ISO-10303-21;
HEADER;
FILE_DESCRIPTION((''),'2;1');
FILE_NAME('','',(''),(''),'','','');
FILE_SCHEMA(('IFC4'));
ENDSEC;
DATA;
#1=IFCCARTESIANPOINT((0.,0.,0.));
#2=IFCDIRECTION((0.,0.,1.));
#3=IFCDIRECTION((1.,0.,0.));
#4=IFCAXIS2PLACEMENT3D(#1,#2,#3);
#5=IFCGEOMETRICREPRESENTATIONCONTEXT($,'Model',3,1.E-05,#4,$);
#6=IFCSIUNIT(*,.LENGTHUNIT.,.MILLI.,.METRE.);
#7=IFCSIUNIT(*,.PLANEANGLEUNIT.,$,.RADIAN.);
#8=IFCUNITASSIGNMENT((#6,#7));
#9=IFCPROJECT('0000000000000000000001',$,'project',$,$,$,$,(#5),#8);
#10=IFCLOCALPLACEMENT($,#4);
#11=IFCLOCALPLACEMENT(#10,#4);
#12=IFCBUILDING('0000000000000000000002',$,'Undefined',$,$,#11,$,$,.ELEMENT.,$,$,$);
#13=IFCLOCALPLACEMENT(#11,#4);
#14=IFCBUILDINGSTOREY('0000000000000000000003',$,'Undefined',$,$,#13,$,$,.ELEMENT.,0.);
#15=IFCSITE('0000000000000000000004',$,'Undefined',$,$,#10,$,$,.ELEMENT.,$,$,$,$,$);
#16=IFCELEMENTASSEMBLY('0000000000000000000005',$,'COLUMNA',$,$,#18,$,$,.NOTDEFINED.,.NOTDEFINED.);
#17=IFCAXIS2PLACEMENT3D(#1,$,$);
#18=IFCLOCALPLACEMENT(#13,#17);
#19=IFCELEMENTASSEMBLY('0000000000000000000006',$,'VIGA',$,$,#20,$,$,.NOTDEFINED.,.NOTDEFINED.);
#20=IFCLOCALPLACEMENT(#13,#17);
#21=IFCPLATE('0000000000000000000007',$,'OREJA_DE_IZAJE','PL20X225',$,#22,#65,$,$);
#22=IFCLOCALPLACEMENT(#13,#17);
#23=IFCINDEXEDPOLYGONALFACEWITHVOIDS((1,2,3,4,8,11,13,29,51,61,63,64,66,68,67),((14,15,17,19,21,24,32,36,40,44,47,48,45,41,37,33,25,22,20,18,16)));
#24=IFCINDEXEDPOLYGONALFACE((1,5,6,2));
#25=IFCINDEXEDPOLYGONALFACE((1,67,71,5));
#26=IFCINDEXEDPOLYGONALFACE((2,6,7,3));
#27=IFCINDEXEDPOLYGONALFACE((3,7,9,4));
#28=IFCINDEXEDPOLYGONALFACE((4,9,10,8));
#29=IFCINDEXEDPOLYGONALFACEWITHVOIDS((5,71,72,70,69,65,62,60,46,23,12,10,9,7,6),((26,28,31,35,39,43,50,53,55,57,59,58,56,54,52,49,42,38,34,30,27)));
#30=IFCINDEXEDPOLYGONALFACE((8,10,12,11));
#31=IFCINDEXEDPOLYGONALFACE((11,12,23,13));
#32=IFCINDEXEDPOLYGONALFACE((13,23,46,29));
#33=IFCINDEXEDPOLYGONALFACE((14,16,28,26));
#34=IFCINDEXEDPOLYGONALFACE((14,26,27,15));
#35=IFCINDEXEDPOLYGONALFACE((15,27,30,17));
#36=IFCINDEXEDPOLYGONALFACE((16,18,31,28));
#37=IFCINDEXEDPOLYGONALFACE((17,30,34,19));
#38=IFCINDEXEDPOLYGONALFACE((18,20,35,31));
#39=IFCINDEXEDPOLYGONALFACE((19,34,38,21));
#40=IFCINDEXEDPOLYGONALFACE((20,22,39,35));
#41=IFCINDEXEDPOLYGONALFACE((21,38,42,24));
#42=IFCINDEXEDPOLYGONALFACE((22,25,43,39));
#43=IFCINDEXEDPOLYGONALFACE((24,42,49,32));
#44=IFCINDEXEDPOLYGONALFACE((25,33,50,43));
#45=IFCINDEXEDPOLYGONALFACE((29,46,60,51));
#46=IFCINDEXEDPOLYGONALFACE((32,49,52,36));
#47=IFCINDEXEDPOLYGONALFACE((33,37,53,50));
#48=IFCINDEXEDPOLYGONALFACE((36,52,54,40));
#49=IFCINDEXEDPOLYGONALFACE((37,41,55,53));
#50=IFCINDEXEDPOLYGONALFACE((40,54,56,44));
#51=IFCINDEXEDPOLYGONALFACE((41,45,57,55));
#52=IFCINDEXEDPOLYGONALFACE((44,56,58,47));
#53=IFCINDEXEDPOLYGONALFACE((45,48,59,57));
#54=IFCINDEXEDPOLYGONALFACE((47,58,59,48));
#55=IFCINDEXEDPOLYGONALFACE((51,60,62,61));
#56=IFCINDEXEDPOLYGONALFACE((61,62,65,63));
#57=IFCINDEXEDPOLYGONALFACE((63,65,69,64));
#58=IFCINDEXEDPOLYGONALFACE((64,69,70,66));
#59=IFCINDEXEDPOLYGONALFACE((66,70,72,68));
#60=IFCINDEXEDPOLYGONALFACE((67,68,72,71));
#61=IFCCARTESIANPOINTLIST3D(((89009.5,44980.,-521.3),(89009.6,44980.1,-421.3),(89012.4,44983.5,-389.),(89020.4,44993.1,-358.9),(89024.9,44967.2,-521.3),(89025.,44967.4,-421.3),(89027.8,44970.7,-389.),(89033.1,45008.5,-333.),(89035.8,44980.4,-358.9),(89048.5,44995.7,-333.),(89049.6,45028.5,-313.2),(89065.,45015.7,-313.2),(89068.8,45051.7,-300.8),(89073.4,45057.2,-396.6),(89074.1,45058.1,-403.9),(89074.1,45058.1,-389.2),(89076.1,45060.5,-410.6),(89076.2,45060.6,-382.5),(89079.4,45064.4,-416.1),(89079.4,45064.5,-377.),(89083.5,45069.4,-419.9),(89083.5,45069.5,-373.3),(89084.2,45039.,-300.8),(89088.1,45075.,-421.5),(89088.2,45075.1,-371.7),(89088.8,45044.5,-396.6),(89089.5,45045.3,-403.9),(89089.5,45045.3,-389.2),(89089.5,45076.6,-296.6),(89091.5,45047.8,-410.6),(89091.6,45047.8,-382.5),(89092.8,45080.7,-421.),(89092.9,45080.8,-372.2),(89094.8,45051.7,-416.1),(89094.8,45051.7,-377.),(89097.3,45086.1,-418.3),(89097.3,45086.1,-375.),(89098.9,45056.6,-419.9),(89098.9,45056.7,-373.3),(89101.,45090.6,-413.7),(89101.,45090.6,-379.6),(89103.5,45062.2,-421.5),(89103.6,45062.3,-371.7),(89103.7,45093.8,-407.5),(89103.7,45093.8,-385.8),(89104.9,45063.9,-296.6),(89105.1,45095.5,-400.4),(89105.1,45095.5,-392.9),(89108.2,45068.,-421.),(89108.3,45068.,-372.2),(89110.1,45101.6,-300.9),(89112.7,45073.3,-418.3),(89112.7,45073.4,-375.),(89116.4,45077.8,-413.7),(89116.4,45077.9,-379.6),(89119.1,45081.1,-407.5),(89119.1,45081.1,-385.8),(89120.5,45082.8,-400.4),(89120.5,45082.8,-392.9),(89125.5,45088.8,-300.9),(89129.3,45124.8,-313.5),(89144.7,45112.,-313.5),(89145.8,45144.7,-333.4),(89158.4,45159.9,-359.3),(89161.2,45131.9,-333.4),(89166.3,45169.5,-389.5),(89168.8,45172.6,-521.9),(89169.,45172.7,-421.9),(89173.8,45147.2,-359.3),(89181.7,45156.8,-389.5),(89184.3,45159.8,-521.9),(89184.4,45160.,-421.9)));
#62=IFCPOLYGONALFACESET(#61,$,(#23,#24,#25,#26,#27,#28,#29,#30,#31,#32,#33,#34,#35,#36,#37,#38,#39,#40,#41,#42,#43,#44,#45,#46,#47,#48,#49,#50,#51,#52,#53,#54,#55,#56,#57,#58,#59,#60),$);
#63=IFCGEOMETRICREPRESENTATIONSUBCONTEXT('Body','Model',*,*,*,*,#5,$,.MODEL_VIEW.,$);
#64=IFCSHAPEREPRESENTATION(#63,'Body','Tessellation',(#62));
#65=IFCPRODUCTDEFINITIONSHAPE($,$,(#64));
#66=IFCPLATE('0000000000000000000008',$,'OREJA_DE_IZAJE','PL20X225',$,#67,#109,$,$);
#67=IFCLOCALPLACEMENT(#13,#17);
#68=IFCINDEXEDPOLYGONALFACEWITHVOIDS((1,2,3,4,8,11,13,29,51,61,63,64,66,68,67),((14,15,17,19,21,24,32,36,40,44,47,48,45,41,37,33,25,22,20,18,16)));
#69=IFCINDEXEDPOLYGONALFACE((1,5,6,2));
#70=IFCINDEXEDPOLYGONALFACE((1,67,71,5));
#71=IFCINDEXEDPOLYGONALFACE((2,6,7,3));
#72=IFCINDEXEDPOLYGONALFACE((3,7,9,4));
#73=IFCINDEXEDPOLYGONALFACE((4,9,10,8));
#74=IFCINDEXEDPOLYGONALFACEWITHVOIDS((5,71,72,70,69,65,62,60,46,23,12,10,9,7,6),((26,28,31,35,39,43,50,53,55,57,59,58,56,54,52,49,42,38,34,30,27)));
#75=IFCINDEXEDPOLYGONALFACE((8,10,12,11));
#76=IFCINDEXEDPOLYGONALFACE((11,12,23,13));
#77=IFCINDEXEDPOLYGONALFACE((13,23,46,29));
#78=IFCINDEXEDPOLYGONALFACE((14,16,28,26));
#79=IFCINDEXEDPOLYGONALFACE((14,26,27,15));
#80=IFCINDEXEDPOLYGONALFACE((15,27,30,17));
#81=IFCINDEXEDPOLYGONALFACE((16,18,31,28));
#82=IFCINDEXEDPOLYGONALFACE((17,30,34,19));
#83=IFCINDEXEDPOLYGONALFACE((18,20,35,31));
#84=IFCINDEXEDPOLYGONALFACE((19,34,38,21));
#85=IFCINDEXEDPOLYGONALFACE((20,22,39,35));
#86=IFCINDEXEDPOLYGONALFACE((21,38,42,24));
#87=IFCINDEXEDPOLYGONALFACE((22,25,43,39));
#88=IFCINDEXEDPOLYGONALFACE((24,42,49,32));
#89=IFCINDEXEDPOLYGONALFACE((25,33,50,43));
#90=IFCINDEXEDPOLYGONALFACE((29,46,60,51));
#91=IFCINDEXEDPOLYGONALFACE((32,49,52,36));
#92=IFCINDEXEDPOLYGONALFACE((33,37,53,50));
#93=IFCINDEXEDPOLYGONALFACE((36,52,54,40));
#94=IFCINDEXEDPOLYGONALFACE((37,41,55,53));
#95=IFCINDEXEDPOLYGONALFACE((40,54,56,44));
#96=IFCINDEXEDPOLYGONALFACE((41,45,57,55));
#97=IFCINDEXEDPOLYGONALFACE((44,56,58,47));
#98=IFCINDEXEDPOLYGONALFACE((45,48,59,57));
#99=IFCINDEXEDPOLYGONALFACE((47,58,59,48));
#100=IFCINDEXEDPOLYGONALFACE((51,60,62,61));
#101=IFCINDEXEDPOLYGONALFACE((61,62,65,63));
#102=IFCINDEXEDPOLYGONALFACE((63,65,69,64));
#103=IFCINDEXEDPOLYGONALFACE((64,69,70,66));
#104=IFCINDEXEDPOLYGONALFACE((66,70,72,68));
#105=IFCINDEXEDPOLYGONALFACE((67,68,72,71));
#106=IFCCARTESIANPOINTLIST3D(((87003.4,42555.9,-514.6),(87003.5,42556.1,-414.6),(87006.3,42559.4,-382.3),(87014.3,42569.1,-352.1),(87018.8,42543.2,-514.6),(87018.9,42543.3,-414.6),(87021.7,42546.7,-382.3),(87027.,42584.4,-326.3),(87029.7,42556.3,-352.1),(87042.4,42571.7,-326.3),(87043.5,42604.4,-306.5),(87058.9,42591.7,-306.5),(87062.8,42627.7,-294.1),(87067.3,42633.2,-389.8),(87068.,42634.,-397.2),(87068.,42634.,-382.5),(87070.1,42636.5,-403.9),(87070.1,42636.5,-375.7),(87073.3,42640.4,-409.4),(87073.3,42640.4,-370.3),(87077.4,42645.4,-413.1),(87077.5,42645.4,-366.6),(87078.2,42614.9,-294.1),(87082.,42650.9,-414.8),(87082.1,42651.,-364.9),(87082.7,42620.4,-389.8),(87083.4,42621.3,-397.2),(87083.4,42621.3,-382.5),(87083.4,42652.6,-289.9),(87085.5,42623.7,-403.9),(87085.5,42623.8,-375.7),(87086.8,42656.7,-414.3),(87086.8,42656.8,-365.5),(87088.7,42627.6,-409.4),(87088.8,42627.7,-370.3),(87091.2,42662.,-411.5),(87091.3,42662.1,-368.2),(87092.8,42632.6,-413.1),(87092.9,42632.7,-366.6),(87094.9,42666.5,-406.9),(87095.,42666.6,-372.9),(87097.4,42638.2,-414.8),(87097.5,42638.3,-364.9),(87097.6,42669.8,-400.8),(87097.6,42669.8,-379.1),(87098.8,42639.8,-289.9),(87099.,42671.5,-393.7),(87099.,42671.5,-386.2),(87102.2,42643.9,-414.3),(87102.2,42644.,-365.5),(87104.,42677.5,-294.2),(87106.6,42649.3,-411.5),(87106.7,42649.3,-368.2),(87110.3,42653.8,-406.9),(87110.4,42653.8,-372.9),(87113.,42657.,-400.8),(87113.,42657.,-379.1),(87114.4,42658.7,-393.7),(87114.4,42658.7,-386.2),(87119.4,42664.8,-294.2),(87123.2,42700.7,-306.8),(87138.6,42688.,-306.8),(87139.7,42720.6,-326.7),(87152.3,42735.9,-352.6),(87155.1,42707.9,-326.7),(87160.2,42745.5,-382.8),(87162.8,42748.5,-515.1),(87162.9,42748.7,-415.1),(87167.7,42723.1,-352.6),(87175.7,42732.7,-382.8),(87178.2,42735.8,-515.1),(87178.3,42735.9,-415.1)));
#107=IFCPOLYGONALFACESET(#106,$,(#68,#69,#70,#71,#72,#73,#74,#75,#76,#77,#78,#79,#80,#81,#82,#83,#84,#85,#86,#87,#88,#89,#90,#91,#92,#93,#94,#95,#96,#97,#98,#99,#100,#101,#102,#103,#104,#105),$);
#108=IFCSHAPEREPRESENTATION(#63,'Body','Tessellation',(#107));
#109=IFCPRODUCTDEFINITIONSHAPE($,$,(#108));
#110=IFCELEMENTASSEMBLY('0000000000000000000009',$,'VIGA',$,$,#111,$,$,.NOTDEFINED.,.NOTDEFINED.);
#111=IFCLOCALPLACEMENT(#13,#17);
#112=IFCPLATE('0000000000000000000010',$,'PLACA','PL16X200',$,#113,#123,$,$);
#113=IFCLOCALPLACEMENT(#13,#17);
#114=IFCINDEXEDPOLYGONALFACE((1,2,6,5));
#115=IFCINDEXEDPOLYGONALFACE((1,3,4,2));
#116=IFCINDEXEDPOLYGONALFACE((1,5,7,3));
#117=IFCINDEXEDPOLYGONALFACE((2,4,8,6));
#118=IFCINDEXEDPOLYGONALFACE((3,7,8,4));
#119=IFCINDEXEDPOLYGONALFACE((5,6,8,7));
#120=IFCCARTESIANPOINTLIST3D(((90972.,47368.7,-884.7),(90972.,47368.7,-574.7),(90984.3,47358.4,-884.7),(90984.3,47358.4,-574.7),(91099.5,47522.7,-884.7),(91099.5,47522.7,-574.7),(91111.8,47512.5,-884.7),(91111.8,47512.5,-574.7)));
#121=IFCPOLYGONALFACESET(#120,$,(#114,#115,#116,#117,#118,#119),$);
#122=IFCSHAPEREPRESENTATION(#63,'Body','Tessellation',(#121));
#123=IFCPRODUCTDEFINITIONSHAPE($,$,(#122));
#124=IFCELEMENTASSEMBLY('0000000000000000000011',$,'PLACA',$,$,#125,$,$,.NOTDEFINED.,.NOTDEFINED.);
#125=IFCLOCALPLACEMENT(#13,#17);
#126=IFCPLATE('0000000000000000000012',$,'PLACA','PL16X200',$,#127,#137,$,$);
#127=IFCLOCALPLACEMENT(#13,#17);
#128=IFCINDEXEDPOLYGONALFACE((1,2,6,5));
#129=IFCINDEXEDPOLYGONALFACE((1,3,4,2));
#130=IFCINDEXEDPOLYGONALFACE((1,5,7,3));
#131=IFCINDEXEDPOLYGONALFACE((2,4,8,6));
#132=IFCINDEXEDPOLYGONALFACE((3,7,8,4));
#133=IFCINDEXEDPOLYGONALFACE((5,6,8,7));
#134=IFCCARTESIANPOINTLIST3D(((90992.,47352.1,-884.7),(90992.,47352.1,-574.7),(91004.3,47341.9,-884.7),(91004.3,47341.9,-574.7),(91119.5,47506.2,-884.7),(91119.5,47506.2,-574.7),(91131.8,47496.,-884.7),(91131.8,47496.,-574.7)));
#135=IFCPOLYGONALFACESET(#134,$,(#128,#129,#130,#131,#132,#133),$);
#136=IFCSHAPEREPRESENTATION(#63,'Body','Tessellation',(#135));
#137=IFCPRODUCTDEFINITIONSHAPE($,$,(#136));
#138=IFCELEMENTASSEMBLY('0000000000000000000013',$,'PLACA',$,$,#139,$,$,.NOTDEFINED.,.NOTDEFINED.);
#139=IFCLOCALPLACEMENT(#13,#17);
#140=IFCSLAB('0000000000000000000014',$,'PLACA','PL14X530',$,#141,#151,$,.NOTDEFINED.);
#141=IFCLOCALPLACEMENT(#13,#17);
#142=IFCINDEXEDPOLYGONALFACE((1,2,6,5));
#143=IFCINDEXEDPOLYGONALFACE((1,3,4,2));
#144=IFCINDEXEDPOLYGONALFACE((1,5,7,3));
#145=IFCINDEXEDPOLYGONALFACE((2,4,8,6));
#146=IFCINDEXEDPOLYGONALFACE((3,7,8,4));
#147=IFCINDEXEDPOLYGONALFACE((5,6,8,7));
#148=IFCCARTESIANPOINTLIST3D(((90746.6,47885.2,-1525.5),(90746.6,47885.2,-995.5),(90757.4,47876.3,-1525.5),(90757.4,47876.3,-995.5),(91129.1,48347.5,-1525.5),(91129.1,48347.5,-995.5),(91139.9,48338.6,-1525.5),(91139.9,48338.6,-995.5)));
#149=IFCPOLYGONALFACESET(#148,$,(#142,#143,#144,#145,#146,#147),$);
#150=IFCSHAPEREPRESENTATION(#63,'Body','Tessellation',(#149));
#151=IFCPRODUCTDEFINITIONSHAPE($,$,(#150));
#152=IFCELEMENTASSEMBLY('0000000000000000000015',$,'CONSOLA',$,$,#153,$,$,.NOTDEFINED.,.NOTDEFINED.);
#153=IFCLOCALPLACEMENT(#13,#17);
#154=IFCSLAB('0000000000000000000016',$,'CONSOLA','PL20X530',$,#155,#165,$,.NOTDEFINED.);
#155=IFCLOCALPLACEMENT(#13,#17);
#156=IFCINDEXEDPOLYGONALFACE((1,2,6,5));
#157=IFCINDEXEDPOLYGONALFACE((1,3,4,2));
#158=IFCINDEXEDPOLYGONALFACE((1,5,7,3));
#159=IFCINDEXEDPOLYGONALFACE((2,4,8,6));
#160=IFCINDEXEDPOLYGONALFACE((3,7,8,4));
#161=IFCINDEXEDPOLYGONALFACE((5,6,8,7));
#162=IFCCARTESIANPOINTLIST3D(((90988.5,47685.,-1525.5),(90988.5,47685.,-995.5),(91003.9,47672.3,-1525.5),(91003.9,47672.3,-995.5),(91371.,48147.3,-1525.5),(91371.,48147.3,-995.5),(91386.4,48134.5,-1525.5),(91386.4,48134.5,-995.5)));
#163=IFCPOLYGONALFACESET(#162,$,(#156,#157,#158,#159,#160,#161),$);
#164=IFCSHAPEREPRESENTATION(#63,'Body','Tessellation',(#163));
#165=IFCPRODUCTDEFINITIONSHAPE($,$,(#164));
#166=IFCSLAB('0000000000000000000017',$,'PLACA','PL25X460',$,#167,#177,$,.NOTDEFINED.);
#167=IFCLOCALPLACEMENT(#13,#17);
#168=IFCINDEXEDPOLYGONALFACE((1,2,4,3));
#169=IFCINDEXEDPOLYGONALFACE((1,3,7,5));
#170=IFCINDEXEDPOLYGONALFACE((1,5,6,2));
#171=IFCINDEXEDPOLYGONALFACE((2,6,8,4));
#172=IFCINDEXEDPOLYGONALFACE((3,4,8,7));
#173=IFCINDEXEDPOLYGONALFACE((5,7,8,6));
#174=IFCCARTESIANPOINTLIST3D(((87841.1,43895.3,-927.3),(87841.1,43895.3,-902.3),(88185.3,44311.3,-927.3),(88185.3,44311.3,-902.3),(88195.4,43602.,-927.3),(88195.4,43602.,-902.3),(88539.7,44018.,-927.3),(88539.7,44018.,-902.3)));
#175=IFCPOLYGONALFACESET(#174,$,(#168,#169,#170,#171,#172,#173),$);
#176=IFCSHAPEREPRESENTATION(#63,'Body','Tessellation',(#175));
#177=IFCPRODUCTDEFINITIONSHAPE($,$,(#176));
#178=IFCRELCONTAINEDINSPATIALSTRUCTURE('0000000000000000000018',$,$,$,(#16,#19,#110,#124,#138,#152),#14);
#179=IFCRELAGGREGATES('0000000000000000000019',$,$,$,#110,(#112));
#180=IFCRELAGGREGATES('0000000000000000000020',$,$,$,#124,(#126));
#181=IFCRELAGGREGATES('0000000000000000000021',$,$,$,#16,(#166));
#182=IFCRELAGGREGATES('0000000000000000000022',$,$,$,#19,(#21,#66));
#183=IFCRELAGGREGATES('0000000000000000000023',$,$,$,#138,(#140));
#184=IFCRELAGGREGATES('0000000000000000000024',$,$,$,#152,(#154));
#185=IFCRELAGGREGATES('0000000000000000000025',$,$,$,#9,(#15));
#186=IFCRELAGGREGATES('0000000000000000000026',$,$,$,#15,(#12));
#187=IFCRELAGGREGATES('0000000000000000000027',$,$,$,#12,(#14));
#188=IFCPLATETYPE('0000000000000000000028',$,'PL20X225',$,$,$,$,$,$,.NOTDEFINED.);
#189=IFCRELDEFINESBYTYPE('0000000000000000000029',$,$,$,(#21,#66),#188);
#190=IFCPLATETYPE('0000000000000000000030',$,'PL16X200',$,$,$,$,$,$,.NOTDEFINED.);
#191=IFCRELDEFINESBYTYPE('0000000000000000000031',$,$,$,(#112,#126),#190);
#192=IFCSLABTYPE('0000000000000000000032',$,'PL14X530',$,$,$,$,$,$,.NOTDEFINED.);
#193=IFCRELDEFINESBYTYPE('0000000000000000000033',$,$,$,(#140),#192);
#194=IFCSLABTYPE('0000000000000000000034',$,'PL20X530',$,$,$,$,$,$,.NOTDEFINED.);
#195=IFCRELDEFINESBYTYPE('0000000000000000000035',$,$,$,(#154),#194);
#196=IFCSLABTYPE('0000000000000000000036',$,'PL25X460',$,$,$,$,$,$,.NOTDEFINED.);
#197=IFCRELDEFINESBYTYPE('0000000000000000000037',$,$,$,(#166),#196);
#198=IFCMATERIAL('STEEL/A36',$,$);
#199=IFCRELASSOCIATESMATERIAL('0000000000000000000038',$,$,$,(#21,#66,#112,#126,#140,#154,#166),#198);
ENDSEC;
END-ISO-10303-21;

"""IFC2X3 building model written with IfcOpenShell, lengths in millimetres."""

from ifc_helpers import new_model, si_unit, frame, frame_2d, origin_with_axes, place, context, subcontext, project, spatial, polyline, circle_curve, parameter, trimmed, segment, composite_curve, outline, extrude, boolean, material, type_object, element, aggregate, save


model = new_model("IFC2X3")

# Units and contexts
model_context = context("Model", 3, precision=1e-05, world=origin_with_axes())
body_context = subcontext(model_context, "Body", "Model", "MODEL_VIEW")
ifc_project = project(units=[si_unit("LENGTHUNIT", "METRE", prefix="MILLI"), si_unit("PLANEANGLEUNIT", "RADIAN")], contexts=[model_context])

# Site, building, storey
site_placement = place(None, origin_with_axes())
site = spatial("IfcSite", under=ifc_project, at=site_placement, Name="Undefined", CompositionType="ELEMENT")
building_placement = place(site_placement, origin_with_axes())
building = spatial("IfcBuilding", under=site, at=building_placement, Name="Undefined", CompositionType="ELEMENT")
storey_placement = place(building_placement, origin_with_axes())
storey = spatial("IfcBuildingStorey", under=building, at=storey_placement, Name="Undefined", CompositionType="ELEMENT", Elevation=0.0)

# Element assembly
assembly_1_placement = place(storey_placement, origin_with_axes())
assembly_1 = element("IfcElementAssembly", 1, at=assembly_1_placement, inside=storey, Name="COLUMNA", AssemblyPlace="NOTDEFINED", PredefinedType="NOTDEFINED")
ifc_material_1 = material(Name="STEEL/A36")

# Element assembly, plates
assembly_2_placement = place(storey_placement, origin_with_axes())
assembly_2 = element("IfcElementAssembly", 2, at=assembly_2_placement, inside=storey, Name="VIGA", AssemblyPlace="NOTDEFINED", PredefinedType="NOTDEFINED")
plate_type_1 = type_object("IfcPlateType", Name="PL20X225", PredefinedType="NOTDEFINED")
plate_1_placement = place(assembly_2_placement, frame((89017.2, 44973.6, -521.3), z_axis=(0.770401, -0.63756, 0.0), x_axis=(0.637558, 0.770399, -0.002141)))
plate_1 = element("IfcPlate", 3, at=plate_1_placement, type_object=plate_type_1, material=ifc_material_1, Name="OREJA_DE_IZAJE", Description="PL20X225", context=body_context, shape_type="CSG", body=[
    boolean("DIFFERENCE", extrude(outline(polyline([(0.0, 0.0), (250.0, 0.0), (250.0, 100.0), (245.7, 132.4), (233.3, 162.5), (213.4, 188.4), (187.5, 208.3), (157.4, 220.7), (125.0, 225.0), (125.0, 225.0), (92.6, 220.7), (62.5, 208.3), (36.6, 188.4), (16.7, 162.5), (4.3, 132.4), (0.0, 100.0), (0.0, 0.0)])), frame((0.0, 0.0, -10.0), z_axis=(0.0, 0.0, 1.0), x_axis=(1.0, 0.0, 0.0)), (0.0, 0.0, 1.0), 20.0), extrude(outline(composite_curve([segment(trimmed(circle_curve(frame_2d((17.7, 17.7), x_axis=(-0.707107, -0.707107)), 25.0), [parameter(0.0)], [parameter(3.141593)], True, "PARAMETER"), True, "CONTINUOUS"), segment(trimmed(circle_curve(frame_2d((17.7, 17.7), x_axis=(0.707107, 0.707107)), 25.0), [parameter(0.0)], [parameter(3.141593)], True, "PARAMETER"), True, "DISCONTINUOUS")], self_intersect=True)), frame((100.0, 125.0, 13.0), z_axis=(0.0, 0.0, -1.0), x_axis=(0.707096, 0.707117, 0.0)), (0.0, 0.0, 1.0), 26.0)),
])
plate_2_placement = place(assembly_2_placement, frame((87011.1, 42549.5, -514.6), z_axis=(0.770401, -0.63756, 0.0), x_axis=(0.637558, 0.770399, -0.002141)))
plate_2 = element("IfcPlate", 4, at=plate_2_placement, type_object=plate_type_1, material=ifc_material_1, Name="OREJA_DE_IZAJE", Description="PL20X225", context=body_context, shape_type="CSG", body=[
    boolean("DIFFERENCE", extrude(outline(polyline([(0.0, 0.0), (250.0, 0.0), (250.0, 100.0), (245.7, 132.4), (233.3, 162.5), (213.4, 188.4), (187.5, 208.3), (157.4, 220.7), (125.0, 225.0), (125.0, 225.0), (92.6, 220.7), (62.5, 208.3), (36.6, 188.4), (16.7, 162.5), (4.3, 132.4), (0.0, 100.0), (0.0, 0.0)])), frame((0.0, 0.0, -10.0), z_axis=(0.0, 0.0, 1.0), x_axis=(1.0, 0.0, 0.0)), (0.0, 0.0, 1.0), 20.0), extrude(outline(composite_curve([segment(trimmed(circle_curve(frame_2d((17.7, 17.7), x_axis=(-0.707107, -0.707107)), 25.0), [parameter(0.0)], [parameter(3.141593)], True, "PARAMETER"), True, "CONTINUOUS"), segment(trimmed(circle_curve(frame_2d((17.7, 17.7), x_axis=(0.707107, 0.707107)), 25.0), [parameter(0.0)], [parameter(3.141593)], True, "PARAMETER"), True, "DISCONTINUOUS")], self_intersect=True)), frame((100.0, 125.0, 13.0), z_axis=(0.0, 0.0, -1.0), x_axis=(0.707096, 0.707117, 0.0)), (0.0, 0.0, 1.0), 26.0)),
])

# Element assemblies, plates
assembly_3_placement = place(storey_placement, origin_with_axes())
assembly_3 = element("IfcElementAssembly", 5, at=assembly_3_placement, inside=storey, Name="VIGA", AssemblyPlace="NOTDEFINED", PredefinedType="NOTDEFINED")
plate_type_2 = type_object("IfcPlateType", Name="PL16X200", PredefinedType="NOTDEFINED")
plate_3_placement = place(assembly_3_placement, frame((91041.9, 47440.6, -574.7), z_axis=(-0.770401, 0.63756, 0.0), x_axis=(0.0, 0.0, -1.0)))
plate_3 = element("IfcPlate", 6, at=plate_3_placement, type_object=plate_type_2, material=ifc_material_1, Name="PLACA", Description="PL16X200", context=body_context, shape_type="SweptSolid", body=[
    extrude(outline(polyline([(0.0, -100.0), (0.0, 100.0), (310.0, 100.0), (310.0, -100.0), (0.0, -100.0)])), frame((0.0, 0.0, -8.0), z_axis=(0.0, 0.0, 1.0), x_axis=(1.0, 0.0, 0.0)), (0.0, 0.0, 1.0), 16.0),
])
aggregate(assembly_3, [plate_3])
assembly_4_placement = place(storey_placement, origin_with_axes())
assembly_4 = element("IfcElementAssembly", 7, at=assembly_4_placement, inside=storey, Name="PLACA", AssemblyPlace="NOTDEFINED", PredefinedType="NOTDEFINED")
plate_4_placement = place(assembly_4_placement, frame((91061.9, 47424.0, -884.7), z_axis=(0.770401, -0.63756, 0.0), x_axis=(0.0, 0.0, 1.0)))
plate_4 = element("IfcPlate", 8, at=plate_4_placement, type_object=plate_type_2, material=ifc_material_1, Name="PLACA", Description="PL16X200", context=body_context, shape_type="SweptSolid", body=[
    extrude(outline(polyline([(0.0, -100.0), (0.0, 100.0), (310.0, 100.0), (310.0, -100.0), (0.0, -100.0)])), frame((0.0, 0.0, -8.0), z_axis=(0.0, 0.0, 1.0), x_axis=(1.0, 0.0, 0.0)), (0.0, 0.0, 1.0), 16.0),
])
aggregate(assembly_4, [plate_4])

# Element assemblies, slabs
assembly_5_placement = place(storey_placement, origin_with_axes())
assembly_5 = element("IfcElementAssembly", 9, at=assembly_5_placement, inside=storey, Name="PLACA", AssemblyPlace="NOTDEFINED", PredefinedType="NOTDEFINED")
slab_type_1 = type_object("IfcSlabType", Name="PL14X530", PredefinedType="NOTDEFINED")
slab_1_placement = place(assembly_5_placement, frame((90752.0, 47880.8, -995.5), z_axis=(-0.770401, 0.63756, 0.0), x_axis=(0.63756, 0.770401, -0.000002)))
slab_1 = element("IfcSlab", 10, at=slab_1_placement, type_object=slab_type_1, material=ifc_material_1, Name="PLACA", Description="PL14X530", PredefinedType="NOTDEFINED", context=body_context, shape_type="SweptSolid", body=[
    extrude(outline(polyline([(0.0, 0.0), (600.0, 0.0), (600.0, 530.0), (0.0, 530.0), (0.0, 0.0)])), frame((0.0, 0.0, -7.0), z_axis=(0.0, 0.0, 1.0), x_axis=(1.0, 0.0, 0.0)), (0.0, 0.0, 1.0), 14.0),
])
assembly_6_placement = place(storey_placement, origin_with_axes())
assembly_6 = element("IfcElementAssembly", 11, at=assembly_6_placement, inside=storey, Name="CONSOLA", AssemblyPlace="NOTDEFINED", PredefinedType="NOTDEFINED")
slab_type_2 = type_object("IfcSlabType", Name="PL20X530", PredefinedType="NOTDEFINED")
slab_2_placement = place(assembly_6_placement, frame((90996.2, 47678.7, -995.5), z_axis=(-0.770401, 0.63756, 0.0), x_axis=(0.63756, 0.770401, -0.000002)))
slab_2 = element("IfcSlab", 12, at=slab_2_placement, type_object=slab_type_2, material=ifc_material_1, Name="CONSOLA", Description="PL20X530", PredefinedType="NOTDEFINED", context=body_context, shape_type="SweptSolid", body=[
    extrude(outline(polyline([(0.0, 0.0), (600.0, 0.0), (600.0, 530.0), (0.0, 530.0), (0.0, 0.0)])), frame((0.0, 0.0, -10.0), z_axis=(0.0, 0.0, 1.0), x_axis=(1.0, 0.0, 0.0)), (0.0, 0.0, 1.0), 20.0),
])

# Slab
slab_type_3 = type_object("IfcSlabType", Name="PL25X460", PredefinedType="NOTDEFINED")
slab_3_placement = place(assembly_1_placement, frame((87841.1, 43895.3, -914.8), z_axis=(0.0, 0.0, 1.0), x_axis=(0.770402, -0.637558, 0.0)))
slab_3 = element("IfcSlab", 13, at=slab_3_placement, type_object=slab_type_3, material=ifc_material_1, Name="PLACA", Description="PL25X460", PredefinedType="NOTDEFINED", context=body_context, shape_type="SweptSolid", body=[
    extrude(outline(polyline([(0.0, 0.0), (460.0, 0.0), (460.0, 540.0), (0.0, 540.0), (0.0, 0.0)])), frame((0.0, 0.0, -12.5), z_axis=(0.0, 0.0, 1.0), x_axis=(1.0, 0.0, 0.0)), (0.0, 0.0, 1.0), 25.0),
])
aggregate(assembly_1, [slab_3])

aggregate(assembly_2, [plate_1, plate_2])

aggregate(assembly_5, [slab_1])
aggregate(assembly_6, [slab_2])

save(model, "model.ifc")
